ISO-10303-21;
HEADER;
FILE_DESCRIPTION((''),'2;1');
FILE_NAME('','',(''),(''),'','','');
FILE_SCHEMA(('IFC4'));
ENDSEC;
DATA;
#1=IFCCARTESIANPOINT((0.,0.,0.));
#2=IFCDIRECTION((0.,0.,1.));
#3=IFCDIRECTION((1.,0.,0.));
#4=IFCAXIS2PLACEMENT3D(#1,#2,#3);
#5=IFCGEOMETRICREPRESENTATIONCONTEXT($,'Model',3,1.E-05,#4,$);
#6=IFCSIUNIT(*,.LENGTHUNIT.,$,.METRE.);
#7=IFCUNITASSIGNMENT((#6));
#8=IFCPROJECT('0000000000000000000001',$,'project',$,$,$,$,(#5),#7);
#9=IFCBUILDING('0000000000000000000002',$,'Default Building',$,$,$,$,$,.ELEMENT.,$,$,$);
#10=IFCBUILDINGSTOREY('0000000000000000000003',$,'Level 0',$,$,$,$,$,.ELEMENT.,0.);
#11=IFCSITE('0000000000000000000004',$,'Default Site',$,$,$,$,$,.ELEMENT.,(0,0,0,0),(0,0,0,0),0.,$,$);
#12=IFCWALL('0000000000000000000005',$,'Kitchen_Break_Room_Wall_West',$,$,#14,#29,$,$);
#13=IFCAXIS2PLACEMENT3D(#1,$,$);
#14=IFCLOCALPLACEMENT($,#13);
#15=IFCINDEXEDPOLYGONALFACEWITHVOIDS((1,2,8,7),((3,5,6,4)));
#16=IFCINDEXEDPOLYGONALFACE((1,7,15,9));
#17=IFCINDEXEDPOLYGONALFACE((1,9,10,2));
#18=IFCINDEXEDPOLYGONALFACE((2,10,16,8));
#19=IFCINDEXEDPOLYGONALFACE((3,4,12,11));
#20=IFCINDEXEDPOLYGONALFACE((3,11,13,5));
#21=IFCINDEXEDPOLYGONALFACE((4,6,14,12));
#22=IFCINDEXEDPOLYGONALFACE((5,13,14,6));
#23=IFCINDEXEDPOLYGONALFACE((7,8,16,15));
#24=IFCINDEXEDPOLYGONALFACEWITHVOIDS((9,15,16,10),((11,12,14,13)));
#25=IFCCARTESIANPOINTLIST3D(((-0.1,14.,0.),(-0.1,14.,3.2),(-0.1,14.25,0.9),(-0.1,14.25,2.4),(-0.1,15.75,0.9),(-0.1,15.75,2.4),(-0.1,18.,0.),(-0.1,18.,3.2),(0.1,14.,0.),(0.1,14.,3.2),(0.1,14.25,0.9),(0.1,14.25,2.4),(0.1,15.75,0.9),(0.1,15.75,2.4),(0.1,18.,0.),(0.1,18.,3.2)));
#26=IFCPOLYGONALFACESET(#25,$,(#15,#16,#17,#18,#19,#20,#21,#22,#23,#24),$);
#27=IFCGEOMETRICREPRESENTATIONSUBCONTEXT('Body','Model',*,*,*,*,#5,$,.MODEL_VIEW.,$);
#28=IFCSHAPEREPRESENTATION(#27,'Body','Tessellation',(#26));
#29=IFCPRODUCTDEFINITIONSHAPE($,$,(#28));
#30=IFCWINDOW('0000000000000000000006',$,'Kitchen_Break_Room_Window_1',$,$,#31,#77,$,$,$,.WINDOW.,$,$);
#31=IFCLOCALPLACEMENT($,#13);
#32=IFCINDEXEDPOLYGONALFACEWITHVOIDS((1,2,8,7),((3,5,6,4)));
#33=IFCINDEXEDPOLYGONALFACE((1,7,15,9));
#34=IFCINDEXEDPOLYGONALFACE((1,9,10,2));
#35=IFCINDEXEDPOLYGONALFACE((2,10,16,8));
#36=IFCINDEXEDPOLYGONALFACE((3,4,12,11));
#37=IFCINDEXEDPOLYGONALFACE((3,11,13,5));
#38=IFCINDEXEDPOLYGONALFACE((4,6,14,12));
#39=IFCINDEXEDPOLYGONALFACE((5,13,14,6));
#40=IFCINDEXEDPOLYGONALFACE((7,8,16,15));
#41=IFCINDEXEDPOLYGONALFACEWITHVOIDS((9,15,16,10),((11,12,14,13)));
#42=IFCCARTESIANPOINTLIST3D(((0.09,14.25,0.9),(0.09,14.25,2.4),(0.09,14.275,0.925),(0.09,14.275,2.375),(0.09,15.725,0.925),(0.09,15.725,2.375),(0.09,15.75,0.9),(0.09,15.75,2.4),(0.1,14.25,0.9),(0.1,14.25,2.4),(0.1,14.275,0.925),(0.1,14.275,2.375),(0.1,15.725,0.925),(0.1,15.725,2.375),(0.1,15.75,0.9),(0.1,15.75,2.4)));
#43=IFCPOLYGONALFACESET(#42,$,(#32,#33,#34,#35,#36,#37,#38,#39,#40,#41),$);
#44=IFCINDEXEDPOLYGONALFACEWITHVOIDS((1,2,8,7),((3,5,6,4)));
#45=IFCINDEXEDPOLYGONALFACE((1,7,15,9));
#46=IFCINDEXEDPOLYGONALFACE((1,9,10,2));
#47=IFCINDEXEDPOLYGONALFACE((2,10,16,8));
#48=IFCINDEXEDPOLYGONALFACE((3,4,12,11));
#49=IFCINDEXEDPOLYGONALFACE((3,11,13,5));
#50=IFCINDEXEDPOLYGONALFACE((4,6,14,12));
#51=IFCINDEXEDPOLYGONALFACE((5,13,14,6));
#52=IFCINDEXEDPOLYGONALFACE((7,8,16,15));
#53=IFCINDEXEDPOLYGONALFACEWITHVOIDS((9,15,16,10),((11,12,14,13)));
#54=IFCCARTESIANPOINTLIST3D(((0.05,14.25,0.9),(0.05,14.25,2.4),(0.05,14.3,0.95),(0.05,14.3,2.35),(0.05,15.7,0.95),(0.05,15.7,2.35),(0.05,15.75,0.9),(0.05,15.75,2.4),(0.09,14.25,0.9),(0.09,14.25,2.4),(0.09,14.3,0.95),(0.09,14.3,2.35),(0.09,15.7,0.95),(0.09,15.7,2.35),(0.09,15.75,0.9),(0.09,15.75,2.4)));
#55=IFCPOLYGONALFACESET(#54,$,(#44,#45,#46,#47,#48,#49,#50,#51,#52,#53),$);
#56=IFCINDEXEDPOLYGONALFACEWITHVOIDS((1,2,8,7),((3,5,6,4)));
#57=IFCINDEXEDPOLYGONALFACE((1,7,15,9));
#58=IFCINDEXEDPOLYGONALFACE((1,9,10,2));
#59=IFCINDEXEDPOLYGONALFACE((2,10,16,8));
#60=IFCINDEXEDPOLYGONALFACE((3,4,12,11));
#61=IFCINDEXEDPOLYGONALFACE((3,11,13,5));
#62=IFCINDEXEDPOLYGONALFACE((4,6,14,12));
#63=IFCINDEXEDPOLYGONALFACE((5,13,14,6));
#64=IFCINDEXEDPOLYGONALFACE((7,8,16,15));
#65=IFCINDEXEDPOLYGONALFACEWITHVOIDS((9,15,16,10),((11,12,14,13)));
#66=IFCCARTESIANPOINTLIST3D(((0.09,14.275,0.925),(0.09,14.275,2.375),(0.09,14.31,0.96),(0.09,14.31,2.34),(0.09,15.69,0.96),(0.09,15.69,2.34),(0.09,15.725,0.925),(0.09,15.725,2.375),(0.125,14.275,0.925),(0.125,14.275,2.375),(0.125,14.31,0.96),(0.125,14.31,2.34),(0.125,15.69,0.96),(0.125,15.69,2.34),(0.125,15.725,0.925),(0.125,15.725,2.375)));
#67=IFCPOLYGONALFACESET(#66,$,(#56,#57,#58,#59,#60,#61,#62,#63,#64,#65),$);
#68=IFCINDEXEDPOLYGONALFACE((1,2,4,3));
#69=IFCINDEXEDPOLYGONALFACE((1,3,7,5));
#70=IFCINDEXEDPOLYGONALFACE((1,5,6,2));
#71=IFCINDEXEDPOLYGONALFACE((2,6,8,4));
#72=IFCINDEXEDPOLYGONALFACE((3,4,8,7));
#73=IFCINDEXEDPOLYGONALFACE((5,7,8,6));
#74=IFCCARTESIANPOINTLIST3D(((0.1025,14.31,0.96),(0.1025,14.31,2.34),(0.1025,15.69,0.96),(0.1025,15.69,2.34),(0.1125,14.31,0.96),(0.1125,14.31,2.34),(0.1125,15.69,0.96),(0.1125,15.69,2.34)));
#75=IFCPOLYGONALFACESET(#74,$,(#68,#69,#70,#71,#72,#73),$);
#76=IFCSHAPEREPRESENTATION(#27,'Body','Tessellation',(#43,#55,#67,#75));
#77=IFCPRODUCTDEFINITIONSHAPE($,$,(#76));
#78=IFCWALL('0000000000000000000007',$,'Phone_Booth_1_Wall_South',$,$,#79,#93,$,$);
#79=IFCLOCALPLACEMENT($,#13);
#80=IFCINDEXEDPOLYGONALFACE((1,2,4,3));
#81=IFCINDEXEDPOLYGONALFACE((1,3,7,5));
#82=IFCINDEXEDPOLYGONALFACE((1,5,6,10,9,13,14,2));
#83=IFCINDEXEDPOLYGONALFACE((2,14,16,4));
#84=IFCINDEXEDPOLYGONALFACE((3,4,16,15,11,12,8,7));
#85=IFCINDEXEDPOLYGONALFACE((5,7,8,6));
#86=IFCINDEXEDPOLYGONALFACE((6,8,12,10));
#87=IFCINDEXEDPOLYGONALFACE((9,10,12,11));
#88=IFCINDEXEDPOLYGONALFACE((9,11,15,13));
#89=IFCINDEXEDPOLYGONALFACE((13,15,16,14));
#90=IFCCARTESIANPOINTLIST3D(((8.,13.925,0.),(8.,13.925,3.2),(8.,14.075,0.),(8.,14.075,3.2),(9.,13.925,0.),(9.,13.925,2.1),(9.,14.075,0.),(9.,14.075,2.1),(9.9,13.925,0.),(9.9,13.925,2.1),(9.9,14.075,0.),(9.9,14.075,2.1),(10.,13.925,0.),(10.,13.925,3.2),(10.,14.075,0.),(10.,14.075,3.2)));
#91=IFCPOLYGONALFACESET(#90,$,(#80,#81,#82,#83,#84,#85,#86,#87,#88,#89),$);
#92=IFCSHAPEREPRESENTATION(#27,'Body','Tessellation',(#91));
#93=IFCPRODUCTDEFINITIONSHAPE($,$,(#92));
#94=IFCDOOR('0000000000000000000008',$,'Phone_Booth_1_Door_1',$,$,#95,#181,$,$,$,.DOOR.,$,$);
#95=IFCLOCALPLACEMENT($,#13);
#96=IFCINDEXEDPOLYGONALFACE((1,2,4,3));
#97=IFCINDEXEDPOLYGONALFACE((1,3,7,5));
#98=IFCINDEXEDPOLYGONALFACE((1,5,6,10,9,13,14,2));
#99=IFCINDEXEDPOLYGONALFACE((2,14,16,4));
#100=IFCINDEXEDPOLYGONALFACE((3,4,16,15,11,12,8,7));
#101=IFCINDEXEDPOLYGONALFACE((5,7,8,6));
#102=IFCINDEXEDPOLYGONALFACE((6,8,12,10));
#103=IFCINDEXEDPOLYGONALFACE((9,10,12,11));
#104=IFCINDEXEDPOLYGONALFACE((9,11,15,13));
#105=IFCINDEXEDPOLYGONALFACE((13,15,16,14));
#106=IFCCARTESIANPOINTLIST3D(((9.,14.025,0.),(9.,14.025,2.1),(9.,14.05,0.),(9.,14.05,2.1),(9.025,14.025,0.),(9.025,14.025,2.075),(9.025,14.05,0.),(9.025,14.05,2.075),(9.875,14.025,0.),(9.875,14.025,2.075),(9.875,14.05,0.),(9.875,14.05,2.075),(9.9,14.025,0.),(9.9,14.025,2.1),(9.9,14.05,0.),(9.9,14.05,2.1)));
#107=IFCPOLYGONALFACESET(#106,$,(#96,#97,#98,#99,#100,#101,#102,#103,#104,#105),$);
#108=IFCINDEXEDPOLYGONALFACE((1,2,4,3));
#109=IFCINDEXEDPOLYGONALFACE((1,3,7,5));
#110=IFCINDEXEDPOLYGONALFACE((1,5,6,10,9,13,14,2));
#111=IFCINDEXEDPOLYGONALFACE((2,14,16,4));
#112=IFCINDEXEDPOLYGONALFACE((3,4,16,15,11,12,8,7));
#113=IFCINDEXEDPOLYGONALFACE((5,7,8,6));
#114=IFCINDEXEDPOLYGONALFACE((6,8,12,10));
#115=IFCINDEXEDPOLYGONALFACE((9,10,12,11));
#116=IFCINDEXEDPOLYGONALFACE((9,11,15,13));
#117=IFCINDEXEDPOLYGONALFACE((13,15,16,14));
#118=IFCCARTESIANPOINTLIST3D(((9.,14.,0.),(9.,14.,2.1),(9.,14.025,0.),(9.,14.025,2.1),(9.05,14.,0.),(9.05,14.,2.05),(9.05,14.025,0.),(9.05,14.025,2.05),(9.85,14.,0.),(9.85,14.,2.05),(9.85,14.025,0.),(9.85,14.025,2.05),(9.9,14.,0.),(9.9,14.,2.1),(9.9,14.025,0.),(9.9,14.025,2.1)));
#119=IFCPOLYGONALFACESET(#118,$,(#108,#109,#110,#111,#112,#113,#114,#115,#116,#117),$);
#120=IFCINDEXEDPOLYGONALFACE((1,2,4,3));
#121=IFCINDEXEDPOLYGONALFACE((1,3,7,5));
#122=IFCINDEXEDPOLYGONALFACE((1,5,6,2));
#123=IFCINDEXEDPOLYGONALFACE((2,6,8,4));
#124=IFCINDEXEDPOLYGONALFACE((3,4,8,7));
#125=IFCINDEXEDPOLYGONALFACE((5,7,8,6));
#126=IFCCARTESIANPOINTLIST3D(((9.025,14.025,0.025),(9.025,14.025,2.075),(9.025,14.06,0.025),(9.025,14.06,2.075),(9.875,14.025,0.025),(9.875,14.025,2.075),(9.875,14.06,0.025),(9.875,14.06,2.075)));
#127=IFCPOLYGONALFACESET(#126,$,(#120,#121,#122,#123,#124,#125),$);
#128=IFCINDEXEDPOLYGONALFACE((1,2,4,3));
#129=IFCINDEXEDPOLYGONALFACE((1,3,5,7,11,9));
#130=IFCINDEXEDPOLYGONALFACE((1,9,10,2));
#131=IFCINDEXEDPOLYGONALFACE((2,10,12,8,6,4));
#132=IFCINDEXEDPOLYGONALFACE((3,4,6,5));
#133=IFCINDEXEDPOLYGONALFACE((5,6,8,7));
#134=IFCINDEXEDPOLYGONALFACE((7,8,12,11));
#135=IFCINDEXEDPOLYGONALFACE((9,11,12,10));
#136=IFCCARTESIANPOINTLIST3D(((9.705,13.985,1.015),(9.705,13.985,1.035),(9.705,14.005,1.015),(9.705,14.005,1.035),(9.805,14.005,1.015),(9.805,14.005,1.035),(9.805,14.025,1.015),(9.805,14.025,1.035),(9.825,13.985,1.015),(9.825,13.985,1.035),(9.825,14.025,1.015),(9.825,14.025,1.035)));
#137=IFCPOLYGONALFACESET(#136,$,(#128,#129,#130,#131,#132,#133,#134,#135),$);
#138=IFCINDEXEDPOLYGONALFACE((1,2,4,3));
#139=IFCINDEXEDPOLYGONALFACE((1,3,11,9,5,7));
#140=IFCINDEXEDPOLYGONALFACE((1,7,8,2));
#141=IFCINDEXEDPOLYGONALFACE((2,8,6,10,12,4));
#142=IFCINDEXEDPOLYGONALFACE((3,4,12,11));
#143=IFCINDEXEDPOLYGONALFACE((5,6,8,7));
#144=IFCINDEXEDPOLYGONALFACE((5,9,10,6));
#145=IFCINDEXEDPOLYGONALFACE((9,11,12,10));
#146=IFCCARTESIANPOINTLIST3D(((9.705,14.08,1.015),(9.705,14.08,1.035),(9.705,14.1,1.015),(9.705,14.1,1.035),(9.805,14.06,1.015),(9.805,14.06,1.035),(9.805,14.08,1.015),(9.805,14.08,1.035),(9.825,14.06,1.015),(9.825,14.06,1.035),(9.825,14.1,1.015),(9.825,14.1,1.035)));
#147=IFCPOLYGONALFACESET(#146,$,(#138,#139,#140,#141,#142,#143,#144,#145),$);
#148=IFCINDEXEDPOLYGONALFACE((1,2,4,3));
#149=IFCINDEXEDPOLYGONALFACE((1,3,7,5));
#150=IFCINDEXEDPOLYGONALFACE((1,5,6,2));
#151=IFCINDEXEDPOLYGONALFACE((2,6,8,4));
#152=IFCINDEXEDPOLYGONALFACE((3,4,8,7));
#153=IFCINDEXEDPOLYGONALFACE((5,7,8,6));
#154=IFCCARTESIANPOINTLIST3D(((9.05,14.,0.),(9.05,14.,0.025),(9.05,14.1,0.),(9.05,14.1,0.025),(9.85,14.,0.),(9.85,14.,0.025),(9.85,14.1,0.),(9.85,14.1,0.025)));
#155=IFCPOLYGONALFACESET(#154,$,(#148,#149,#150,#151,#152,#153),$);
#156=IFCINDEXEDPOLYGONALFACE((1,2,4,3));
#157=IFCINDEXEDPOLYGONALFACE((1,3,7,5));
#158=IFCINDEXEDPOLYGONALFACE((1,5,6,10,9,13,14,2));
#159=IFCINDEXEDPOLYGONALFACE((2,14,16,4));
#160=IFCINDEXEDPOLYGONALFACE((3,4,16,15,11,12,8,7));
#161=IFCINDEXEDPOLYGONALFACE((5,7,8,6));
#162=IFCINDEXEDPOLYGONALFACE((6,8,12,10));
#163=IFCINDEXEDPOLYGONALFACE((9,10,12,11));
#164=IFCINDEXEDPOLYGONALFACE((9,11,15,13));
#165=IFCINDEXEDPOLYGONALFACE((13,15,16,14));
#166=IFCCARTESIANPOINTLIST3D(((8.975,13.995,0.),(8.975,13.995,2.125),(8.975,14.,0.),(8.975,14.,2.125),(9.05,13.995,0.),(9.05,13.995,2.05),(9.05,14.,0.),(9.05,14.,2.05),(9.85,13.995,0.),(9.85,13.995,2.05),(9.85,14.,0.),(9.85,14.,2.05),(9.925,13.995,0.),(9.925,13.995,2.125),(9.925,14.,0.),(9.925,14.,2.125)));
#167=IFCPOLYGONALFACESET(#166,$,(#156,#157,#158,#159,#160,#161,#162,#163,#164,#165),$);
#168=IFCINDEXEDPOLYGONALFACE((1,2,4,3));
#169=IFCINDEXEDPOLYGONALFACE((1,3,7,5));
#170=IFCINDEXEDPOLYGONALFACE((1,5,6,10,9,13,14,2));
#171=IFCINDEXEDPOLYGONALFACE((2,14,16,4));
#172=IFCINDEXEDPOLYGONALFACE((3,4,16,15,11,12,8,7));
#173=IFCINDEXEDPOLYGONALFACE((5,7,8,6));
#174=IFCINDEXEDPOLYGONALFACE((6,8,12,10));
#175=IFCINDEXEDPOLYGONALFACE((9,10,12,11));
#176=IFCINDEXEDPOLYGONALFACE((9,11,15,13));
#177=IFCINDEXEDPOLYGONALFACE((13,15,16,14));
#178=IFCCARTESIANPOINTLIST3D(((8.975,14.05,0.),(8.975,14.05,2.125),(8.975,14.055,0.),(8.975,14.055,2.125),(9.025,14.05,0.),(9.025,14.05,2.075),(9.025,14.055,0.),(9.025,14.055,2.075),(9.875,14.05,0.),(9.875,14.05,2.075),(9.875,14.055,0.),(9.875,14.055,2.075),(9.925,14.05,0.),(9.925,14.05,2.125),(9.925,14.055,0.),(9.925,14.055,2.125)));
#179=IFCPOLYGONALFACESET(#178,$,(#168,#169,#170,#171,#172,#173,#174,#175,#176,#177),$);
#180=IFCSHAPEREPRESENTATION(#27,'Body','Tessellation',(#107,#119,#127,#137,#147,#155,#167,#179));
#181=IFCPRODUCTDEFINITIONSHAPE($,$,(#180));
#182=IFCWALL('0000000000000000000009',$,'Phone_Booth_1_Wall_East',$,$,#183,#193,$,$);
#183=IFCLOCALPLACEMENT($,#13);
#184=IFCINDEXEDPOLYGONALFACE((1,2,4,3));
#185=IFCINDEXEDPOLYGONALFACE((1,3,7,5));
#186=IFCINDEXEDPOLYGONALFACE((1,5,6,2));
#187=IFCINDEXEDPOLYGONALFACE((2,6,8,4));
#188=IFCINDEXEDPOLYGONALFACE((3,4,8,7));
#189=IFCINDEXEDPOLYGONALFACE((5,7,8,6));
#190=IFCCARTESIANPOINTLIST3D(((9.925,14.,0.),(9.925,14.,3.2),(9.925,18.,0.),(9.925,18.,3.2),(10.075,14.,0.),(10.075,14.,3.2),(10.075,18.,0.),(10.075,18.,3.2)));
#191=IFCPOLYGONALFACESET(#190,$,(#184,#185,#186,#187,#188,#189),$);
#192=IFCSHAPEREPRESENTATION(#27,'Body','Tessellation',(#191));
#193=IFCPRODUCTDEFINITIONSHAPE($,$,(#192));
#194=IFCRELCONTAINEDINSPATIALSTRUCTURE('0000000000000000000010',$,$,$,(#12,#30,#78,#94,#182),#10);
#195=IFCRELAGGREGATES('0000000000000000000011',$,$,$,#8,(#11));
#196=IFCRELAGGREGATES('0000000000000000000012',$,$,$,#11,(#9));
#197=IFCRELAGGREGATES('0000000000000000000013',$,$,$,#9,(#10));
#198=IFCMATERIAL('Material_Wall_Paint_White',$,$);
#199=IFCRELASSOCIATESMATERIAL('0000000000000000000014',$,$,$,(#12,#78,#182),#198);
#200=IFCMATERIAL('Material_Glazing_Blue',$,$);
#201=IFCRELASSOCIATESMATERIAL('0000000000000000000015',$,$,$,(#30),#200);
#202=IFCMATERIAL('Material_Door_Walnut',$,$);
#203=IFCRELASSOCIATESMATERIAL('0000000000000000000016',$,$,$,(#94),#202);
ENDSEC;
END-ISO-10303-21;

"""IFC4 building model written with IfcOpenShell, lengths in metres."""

from ifc_helpers import new_model, si_unit, frame, origin_with_axes, place, context, subcontext, project, spatial, line, indexed_curve, outline, extrude, material, element, fill, save


model = new_model("IFC4")

# Units and contexts
model_context = context("Model", 3, precision=1e-05, world=origin_with_axes())
body_context = subcontext(model_context, "Body", "Model", "MODEL_VIEW")
ifc_project = project(units=[si_unit("LENGTHUNIT", "METRE")], contexts=[model_context])

# Site, building, storey
site = spatial("IfcSite", under=ifc_project, Name="Default Site", CompositionType="ELEMENT", RefLatitude=(0, 0, 0, 0), RefLongitude=(0, 0, 0, 0), RefElevation=0.0)
building = spatial("IfcBuilding", under=site, Name="Default Building", CompositionType="ELEMENT")
storey = spatial("IfcBuildingStorey", under=building, Name="Level 0", CompositionType="ELEMENT", Elevation=0.0)

# Shared definitions
ifc_material_1 = material(Name="Material_Wall_Paint_White")

# Shared definitions
ifc_material_2 = material(Name="Material_Glazing_Blue")

# Shared definitions
ifc_material_3 = material(Name="Material_Door_Walnut")

# Wall, opening, window
wall_1_placement = place(None, frame((0.0, 18.0, 0.0), z_axis=(0.0, 0.0, 1.0), x_axis=(0.0, -1.0, 0.0)))
wall_1 = element("IfcWall", 1, at=wall_1_placement, inside=storey, material=ifc_material_1, Name="Kitchen_Break_Room_Wall_West", context=body_context, shape_type="SweptSolid", body=[
    extrude(outline(indexed_curve([(0.0, 0.0), (0.0, 0.2), (4.0, 0.2), (4.0, 0.0), (0.0, 0.0)], self_intersect=False)), frame((0.0, -0.1, 0.0), z_axis=(0.0, 0.0, 1.0), x_axis=(1.0, 0.0, 0.0)), (0.0, 0.0, 1.0), 3.2),
])
opening_1_placement = place(wall_1_placement, frame((2.25, -0.5, 0.9), z_axis=(0.0, 0.0, 1.0), x_axis=(1.0, 0.0, 0.0)))
opening_1 = element("IfcOpeningElement", 2, at=opening_1_placement, inside=storey, cuts=wall_1, PredefinedType="OPENING", context=body_context, shape_type="SweptSolid", body=[
    extrude(outline(indexed_curve([(0.0, 0.0), (0.0, 1.0), (1.5, 1.0), (1.5, 0.0), (0.0, 0.0)], self_intersect=False)), origin_with_axes(), (0.0, 0.0, 1.0), 1.5),
])
window_1_placement = place(None, frame((0.0, 15.75, 0.9), z_axis=(0.0, 0.0, 1.0), x_axis=(0.0, -1.0, 0.0)))
window_1 = element("IfcWindow", 3, at=window_1_placement, inside=storey, material=ifc_material_2, Name="Kitchen_Break_Room_Window_1", PredefinedType="WINDOW", context=body_context, shape_type="SweptSolid", body=[
    extrude(outline(indexed_curve([(0.0, 0.0), (1.5, 0.0), (1.5, 1.5), (0.0, 1.5)], segments=[line(1, 2, 3, 4, 1)]), holes=[indexed_curve([(0.025, 0.025), (1.475, 0.025), (1.475, 1.475), (0.025, 1.475)], segments=[line(1, 2, 3, 4, 1)])]), frame((0.0, 0.09, 0.0), z_axis=(0.0, -1.0, 0.0), x_axis=(1.0, 0.0, 0.0)), (0.0, 0.0, -1.0), 0.01),
    extrude(outline(indexed_curve([(0.0, 0.0), (1.5, 0.0), (1.5, 1.5), (0.0, 1.5)], segments=[line(1, 2, 3, 4, 1)]), holes=[indexed_curve([(0.05, 0.05), (1.45, 0.05), (1.45, 1.45), (0.05, 1.45)], segments=[line(1, 2, 3, 4, 1)])]), frame((0.0, 0.05, 0.0), z_axis=(0.0, -1.0, 0.0), x_axis=(1.0, 0.0, 0.0)), (0.0, 0.0, -1.0), 0.04),
    extrude(outline(indexed_curve([(0.0, 0.0), (1.45, 0.0), (1.45, 1.45), (0.0, 1.45)], segments=[line(1, 2, 3, 4, 1)]), holes=[indexed_curve([(0.035, 0.035), (1.415, 0.035), (1.415, 1.415), (0.035, 1.415)], segments=[line(1, 2, 3, 4, 1)])]), frame((0.025, 0.09, 0.025), z_axis=(0.0, -1.0, 0.0), x_axis=(1.0, 0.0, 0.0)), (0.0, 0.0, -1.0), 0.035),
    extrude(outline(indexed_curve([(0.035, 0.035), (1.415, 0.035), (1.415, 1.415), (0.035, 1.415)], segments=[line(1, 2, 3, 4, 1)])), frame((0.025, 0.1025, 0.025), z_axis=(0.0, -1.0, 0.0), x_axis=(1.0, 0.0, 0.0)), (0.0, 0.0, -1.0), 0.01),
])
fill(opening_1, window_1)

# Wall, opening, door
wall_2_placement = place(None, frame((8.0, 14.0, 0.0), z_axis=(0.0, 0.0, 1.0), x_axis=(1.0, 0.0, 0.0)))
wall_2 = element("IfcWall", 4, at=wall_2_placement, inside=storey, material=ifc_material_1, Name="Phone_Booth_1_Wall_South", context=body_context, shape_type="SweptSolid", body=[
    extrude(outline(indexed_curve([(0.0, 0.0), (0.0, 0.15), (2.0, 0.15), (2.0, 0.0), (0.0, 0.0)], self_intersect=False)), frame((0.0, -0.075, 0.0), z_axis=(0.0, 0.0, 1.0), x_axis=(1.0, 0.0, 0.0)), (0.0, 0.0, 1.0), 3.2),
])
opening_2_placement = place(wall_2_placement, frame((1.0, -0.5, 0.0), z_axis=(0.0, 0.0, 1.0), x_axis=(1.0, 0.0, 0.0)))
opening_2 = element("IfcOpeningElement", 5, at=opening_2_placement, inside=storey, cuts=wall_2, PredefinedType="OPENING", context=body_context, shape_type="SweptSolid", body=[
    extrude(outline(indexed_curve([(0.0, 0.0), (0.0, 1.0), (0.9, 1.0), (0.9, 0.0), (0.0, 0.0)], self_intersect=False)), origin_with_axes(), (0.0, 0.0, 1.0), 2.1),
])
door_1_placement = place(None, frame((9.0, 14.0, 0.0), z_axis=(0.0, 0.0, 1.0), x_axis=(1.0, 0.0, 0.0)))
door_1 = element("IfcDoor", 6, at=door_1_placement, inside=storey, material=ifc_material_3, Name="Phone_Booth_1_Door_1", PredefinedType="DOOR", context=body_context, shape_type="SweptSolid", body=[
    extrude(outline(indexed_curve([(0.0, 0.0), (0.0, 2.1), (0.9, 2.1), (0.9, 0.0), (0.875, 0.0), (0.875, 2.075), (0.025, 2.075), (0.025, 0.0)], segments=[line(1, 2, 3, 4, 5, 6, 7, 8, 1)])), frame((0.0, 0.025, 0.0), z_axis=(0.0, -1.0, 0.0), x_axis=(1.0, 0.0, 0.0)), (0.0, 0.0, -1.0), 0.025),
    extrude(outline(indexed_curve([(0.0, 0.0), (0.0, 2.1), (0.9, 2.1), (0.9, 0.0), (0.85, 0.0), (0.85, 2.05), (0.05, 2.05), (0.05, 0.0)], segments=[line(1, 2, 3, 4, 5, 6, 7, 8, 1)])), frame((0.0, 0.0, 0.0), z_axis=(0.0, -1.0, 0.0), x_axis=(1.0, 0.0, 0.0)), (0.0, 0.0, -1.0), 0.025),
    extrude(outline(indexed_curve([(0.0, 0.0), (0.85, 0.0), (0.85, 0.035), (0.0, 0.035)], segments=[line(1, 2, 3, 4, 1)])), frame((0.025, 0.025, 0.025), z_axis=(0.0, 0.0, 1.0), x_axis=(1.0, 0.0, 0.0)), (0.0, 0.0, 1.0), 2.05),
    extrude(outline(indexed_curve([(0.0, 0.0), (0.0, -0.04), (-0.12, -0.04), (-0.12, -0.02), (-0.02, -0.02), (-0.02, 0.0)], segments=[line(1, 2, 3, 4, 5, 6, 1)])), frame((0.825, 0.025, 1.015), z_axis=(0.0, 0.0, 1.0), x_axis=(1.0, 0.0, 0.0)), (0.0, 0.0, 1.0), 0.02),
    extrude(outline(indexed_curve([(0.0, 0.0), (0.0, 0.04), (-0.12, 0.04), (-0.12, 0.02), (-0.02, 0.02), (-0.02, 0.0)], segments=[line(1, 2, 3, 4, 5, 6, 1)])), frame((0.825, 0.06, 1.015), z_axis=(0.0, 0.0, 1.0), x_axis=(1.0, 0.0, 0.0)), (0.0, 0.0, 1.0), 0.02),
    extrude(outline(indexed_curve([(0.0, 0.0), (0.8, 0.0), (0.8, 0.1), (0.0, 0.1)], segments=[line(1, 2, 3, 4, 1)])), frame((0.05, 0.0, 0.0), z_axis=(0.0, 0.0, 1.0), x_axis=(1.0, 0.0, 0.0)), (0.0, 0.0, 1.0), 0.025),
    extrude(outline(indexed_curve([(0.0, 0.0), (0.0, 2.125), (0.95, 2.125), (0.95, 0.0), (0.875, 0.0), (0.875, 2.05), (0.075, 2.05), (0.075, 0.0)], segments=[line(1, 2, 3, 4, 5, 6, 7, 8, 1)])), frame((-0.025, -0.005, 0.0), z_axis=(0.0, -1.0, 0.0), x_axis=(1.0, 0.0, 0.0)), (0.0, 0.0, -1.0), 0.005),
    extrude(outline(indexed_curve([(0.0, 0.0), (0.0, 2.125), (0.95, 2.125), (0.95, 0.0), (0.9, 0.0), (0.9, 2.075), (0.05, 2.075), (0.05, 0.0)], segments=[line(1, 2, 3, 4, 5, 6, 7, 8, 1)])), frame((-0.025, 0.05, 0.0), z_axis=(0.0, -1.0, 0.0), x_axis=(1.0, 0.0, 0.0)), (0.0, 0.0, -1.0), 0.005),
])
fill(opening_2, door_1)

# Wall
wall_3_placement = place(None, frame((10.0, 14.0, 0.0), z_axis=(0.0, 0.0, 1.0), x_axis=(0.0, 1.0, 0.0)))
element("IfcWall", 7, at=wall_3_placement, inside=storey, material=ifc_material_1, Name="Phone_Booth_1_Wall_East", context=body_context, shape_type="SweptSolid", body=[
    extrude(outline(indexed_curve([(0.0, 0.0), (0.0, 0.15), (4.0, 0.15), (4.0, 0.0), (0.0, 0.0)], self_intersect=False)), frame((0.0, -0.075, 0.0), z_axis=(0.0, 0.0, 1.0), x_axis=(1.0, 0.0, 0.0)), (0.0, 0.0, 1.0), 3.2),
])

save(model, "model.ifc")
